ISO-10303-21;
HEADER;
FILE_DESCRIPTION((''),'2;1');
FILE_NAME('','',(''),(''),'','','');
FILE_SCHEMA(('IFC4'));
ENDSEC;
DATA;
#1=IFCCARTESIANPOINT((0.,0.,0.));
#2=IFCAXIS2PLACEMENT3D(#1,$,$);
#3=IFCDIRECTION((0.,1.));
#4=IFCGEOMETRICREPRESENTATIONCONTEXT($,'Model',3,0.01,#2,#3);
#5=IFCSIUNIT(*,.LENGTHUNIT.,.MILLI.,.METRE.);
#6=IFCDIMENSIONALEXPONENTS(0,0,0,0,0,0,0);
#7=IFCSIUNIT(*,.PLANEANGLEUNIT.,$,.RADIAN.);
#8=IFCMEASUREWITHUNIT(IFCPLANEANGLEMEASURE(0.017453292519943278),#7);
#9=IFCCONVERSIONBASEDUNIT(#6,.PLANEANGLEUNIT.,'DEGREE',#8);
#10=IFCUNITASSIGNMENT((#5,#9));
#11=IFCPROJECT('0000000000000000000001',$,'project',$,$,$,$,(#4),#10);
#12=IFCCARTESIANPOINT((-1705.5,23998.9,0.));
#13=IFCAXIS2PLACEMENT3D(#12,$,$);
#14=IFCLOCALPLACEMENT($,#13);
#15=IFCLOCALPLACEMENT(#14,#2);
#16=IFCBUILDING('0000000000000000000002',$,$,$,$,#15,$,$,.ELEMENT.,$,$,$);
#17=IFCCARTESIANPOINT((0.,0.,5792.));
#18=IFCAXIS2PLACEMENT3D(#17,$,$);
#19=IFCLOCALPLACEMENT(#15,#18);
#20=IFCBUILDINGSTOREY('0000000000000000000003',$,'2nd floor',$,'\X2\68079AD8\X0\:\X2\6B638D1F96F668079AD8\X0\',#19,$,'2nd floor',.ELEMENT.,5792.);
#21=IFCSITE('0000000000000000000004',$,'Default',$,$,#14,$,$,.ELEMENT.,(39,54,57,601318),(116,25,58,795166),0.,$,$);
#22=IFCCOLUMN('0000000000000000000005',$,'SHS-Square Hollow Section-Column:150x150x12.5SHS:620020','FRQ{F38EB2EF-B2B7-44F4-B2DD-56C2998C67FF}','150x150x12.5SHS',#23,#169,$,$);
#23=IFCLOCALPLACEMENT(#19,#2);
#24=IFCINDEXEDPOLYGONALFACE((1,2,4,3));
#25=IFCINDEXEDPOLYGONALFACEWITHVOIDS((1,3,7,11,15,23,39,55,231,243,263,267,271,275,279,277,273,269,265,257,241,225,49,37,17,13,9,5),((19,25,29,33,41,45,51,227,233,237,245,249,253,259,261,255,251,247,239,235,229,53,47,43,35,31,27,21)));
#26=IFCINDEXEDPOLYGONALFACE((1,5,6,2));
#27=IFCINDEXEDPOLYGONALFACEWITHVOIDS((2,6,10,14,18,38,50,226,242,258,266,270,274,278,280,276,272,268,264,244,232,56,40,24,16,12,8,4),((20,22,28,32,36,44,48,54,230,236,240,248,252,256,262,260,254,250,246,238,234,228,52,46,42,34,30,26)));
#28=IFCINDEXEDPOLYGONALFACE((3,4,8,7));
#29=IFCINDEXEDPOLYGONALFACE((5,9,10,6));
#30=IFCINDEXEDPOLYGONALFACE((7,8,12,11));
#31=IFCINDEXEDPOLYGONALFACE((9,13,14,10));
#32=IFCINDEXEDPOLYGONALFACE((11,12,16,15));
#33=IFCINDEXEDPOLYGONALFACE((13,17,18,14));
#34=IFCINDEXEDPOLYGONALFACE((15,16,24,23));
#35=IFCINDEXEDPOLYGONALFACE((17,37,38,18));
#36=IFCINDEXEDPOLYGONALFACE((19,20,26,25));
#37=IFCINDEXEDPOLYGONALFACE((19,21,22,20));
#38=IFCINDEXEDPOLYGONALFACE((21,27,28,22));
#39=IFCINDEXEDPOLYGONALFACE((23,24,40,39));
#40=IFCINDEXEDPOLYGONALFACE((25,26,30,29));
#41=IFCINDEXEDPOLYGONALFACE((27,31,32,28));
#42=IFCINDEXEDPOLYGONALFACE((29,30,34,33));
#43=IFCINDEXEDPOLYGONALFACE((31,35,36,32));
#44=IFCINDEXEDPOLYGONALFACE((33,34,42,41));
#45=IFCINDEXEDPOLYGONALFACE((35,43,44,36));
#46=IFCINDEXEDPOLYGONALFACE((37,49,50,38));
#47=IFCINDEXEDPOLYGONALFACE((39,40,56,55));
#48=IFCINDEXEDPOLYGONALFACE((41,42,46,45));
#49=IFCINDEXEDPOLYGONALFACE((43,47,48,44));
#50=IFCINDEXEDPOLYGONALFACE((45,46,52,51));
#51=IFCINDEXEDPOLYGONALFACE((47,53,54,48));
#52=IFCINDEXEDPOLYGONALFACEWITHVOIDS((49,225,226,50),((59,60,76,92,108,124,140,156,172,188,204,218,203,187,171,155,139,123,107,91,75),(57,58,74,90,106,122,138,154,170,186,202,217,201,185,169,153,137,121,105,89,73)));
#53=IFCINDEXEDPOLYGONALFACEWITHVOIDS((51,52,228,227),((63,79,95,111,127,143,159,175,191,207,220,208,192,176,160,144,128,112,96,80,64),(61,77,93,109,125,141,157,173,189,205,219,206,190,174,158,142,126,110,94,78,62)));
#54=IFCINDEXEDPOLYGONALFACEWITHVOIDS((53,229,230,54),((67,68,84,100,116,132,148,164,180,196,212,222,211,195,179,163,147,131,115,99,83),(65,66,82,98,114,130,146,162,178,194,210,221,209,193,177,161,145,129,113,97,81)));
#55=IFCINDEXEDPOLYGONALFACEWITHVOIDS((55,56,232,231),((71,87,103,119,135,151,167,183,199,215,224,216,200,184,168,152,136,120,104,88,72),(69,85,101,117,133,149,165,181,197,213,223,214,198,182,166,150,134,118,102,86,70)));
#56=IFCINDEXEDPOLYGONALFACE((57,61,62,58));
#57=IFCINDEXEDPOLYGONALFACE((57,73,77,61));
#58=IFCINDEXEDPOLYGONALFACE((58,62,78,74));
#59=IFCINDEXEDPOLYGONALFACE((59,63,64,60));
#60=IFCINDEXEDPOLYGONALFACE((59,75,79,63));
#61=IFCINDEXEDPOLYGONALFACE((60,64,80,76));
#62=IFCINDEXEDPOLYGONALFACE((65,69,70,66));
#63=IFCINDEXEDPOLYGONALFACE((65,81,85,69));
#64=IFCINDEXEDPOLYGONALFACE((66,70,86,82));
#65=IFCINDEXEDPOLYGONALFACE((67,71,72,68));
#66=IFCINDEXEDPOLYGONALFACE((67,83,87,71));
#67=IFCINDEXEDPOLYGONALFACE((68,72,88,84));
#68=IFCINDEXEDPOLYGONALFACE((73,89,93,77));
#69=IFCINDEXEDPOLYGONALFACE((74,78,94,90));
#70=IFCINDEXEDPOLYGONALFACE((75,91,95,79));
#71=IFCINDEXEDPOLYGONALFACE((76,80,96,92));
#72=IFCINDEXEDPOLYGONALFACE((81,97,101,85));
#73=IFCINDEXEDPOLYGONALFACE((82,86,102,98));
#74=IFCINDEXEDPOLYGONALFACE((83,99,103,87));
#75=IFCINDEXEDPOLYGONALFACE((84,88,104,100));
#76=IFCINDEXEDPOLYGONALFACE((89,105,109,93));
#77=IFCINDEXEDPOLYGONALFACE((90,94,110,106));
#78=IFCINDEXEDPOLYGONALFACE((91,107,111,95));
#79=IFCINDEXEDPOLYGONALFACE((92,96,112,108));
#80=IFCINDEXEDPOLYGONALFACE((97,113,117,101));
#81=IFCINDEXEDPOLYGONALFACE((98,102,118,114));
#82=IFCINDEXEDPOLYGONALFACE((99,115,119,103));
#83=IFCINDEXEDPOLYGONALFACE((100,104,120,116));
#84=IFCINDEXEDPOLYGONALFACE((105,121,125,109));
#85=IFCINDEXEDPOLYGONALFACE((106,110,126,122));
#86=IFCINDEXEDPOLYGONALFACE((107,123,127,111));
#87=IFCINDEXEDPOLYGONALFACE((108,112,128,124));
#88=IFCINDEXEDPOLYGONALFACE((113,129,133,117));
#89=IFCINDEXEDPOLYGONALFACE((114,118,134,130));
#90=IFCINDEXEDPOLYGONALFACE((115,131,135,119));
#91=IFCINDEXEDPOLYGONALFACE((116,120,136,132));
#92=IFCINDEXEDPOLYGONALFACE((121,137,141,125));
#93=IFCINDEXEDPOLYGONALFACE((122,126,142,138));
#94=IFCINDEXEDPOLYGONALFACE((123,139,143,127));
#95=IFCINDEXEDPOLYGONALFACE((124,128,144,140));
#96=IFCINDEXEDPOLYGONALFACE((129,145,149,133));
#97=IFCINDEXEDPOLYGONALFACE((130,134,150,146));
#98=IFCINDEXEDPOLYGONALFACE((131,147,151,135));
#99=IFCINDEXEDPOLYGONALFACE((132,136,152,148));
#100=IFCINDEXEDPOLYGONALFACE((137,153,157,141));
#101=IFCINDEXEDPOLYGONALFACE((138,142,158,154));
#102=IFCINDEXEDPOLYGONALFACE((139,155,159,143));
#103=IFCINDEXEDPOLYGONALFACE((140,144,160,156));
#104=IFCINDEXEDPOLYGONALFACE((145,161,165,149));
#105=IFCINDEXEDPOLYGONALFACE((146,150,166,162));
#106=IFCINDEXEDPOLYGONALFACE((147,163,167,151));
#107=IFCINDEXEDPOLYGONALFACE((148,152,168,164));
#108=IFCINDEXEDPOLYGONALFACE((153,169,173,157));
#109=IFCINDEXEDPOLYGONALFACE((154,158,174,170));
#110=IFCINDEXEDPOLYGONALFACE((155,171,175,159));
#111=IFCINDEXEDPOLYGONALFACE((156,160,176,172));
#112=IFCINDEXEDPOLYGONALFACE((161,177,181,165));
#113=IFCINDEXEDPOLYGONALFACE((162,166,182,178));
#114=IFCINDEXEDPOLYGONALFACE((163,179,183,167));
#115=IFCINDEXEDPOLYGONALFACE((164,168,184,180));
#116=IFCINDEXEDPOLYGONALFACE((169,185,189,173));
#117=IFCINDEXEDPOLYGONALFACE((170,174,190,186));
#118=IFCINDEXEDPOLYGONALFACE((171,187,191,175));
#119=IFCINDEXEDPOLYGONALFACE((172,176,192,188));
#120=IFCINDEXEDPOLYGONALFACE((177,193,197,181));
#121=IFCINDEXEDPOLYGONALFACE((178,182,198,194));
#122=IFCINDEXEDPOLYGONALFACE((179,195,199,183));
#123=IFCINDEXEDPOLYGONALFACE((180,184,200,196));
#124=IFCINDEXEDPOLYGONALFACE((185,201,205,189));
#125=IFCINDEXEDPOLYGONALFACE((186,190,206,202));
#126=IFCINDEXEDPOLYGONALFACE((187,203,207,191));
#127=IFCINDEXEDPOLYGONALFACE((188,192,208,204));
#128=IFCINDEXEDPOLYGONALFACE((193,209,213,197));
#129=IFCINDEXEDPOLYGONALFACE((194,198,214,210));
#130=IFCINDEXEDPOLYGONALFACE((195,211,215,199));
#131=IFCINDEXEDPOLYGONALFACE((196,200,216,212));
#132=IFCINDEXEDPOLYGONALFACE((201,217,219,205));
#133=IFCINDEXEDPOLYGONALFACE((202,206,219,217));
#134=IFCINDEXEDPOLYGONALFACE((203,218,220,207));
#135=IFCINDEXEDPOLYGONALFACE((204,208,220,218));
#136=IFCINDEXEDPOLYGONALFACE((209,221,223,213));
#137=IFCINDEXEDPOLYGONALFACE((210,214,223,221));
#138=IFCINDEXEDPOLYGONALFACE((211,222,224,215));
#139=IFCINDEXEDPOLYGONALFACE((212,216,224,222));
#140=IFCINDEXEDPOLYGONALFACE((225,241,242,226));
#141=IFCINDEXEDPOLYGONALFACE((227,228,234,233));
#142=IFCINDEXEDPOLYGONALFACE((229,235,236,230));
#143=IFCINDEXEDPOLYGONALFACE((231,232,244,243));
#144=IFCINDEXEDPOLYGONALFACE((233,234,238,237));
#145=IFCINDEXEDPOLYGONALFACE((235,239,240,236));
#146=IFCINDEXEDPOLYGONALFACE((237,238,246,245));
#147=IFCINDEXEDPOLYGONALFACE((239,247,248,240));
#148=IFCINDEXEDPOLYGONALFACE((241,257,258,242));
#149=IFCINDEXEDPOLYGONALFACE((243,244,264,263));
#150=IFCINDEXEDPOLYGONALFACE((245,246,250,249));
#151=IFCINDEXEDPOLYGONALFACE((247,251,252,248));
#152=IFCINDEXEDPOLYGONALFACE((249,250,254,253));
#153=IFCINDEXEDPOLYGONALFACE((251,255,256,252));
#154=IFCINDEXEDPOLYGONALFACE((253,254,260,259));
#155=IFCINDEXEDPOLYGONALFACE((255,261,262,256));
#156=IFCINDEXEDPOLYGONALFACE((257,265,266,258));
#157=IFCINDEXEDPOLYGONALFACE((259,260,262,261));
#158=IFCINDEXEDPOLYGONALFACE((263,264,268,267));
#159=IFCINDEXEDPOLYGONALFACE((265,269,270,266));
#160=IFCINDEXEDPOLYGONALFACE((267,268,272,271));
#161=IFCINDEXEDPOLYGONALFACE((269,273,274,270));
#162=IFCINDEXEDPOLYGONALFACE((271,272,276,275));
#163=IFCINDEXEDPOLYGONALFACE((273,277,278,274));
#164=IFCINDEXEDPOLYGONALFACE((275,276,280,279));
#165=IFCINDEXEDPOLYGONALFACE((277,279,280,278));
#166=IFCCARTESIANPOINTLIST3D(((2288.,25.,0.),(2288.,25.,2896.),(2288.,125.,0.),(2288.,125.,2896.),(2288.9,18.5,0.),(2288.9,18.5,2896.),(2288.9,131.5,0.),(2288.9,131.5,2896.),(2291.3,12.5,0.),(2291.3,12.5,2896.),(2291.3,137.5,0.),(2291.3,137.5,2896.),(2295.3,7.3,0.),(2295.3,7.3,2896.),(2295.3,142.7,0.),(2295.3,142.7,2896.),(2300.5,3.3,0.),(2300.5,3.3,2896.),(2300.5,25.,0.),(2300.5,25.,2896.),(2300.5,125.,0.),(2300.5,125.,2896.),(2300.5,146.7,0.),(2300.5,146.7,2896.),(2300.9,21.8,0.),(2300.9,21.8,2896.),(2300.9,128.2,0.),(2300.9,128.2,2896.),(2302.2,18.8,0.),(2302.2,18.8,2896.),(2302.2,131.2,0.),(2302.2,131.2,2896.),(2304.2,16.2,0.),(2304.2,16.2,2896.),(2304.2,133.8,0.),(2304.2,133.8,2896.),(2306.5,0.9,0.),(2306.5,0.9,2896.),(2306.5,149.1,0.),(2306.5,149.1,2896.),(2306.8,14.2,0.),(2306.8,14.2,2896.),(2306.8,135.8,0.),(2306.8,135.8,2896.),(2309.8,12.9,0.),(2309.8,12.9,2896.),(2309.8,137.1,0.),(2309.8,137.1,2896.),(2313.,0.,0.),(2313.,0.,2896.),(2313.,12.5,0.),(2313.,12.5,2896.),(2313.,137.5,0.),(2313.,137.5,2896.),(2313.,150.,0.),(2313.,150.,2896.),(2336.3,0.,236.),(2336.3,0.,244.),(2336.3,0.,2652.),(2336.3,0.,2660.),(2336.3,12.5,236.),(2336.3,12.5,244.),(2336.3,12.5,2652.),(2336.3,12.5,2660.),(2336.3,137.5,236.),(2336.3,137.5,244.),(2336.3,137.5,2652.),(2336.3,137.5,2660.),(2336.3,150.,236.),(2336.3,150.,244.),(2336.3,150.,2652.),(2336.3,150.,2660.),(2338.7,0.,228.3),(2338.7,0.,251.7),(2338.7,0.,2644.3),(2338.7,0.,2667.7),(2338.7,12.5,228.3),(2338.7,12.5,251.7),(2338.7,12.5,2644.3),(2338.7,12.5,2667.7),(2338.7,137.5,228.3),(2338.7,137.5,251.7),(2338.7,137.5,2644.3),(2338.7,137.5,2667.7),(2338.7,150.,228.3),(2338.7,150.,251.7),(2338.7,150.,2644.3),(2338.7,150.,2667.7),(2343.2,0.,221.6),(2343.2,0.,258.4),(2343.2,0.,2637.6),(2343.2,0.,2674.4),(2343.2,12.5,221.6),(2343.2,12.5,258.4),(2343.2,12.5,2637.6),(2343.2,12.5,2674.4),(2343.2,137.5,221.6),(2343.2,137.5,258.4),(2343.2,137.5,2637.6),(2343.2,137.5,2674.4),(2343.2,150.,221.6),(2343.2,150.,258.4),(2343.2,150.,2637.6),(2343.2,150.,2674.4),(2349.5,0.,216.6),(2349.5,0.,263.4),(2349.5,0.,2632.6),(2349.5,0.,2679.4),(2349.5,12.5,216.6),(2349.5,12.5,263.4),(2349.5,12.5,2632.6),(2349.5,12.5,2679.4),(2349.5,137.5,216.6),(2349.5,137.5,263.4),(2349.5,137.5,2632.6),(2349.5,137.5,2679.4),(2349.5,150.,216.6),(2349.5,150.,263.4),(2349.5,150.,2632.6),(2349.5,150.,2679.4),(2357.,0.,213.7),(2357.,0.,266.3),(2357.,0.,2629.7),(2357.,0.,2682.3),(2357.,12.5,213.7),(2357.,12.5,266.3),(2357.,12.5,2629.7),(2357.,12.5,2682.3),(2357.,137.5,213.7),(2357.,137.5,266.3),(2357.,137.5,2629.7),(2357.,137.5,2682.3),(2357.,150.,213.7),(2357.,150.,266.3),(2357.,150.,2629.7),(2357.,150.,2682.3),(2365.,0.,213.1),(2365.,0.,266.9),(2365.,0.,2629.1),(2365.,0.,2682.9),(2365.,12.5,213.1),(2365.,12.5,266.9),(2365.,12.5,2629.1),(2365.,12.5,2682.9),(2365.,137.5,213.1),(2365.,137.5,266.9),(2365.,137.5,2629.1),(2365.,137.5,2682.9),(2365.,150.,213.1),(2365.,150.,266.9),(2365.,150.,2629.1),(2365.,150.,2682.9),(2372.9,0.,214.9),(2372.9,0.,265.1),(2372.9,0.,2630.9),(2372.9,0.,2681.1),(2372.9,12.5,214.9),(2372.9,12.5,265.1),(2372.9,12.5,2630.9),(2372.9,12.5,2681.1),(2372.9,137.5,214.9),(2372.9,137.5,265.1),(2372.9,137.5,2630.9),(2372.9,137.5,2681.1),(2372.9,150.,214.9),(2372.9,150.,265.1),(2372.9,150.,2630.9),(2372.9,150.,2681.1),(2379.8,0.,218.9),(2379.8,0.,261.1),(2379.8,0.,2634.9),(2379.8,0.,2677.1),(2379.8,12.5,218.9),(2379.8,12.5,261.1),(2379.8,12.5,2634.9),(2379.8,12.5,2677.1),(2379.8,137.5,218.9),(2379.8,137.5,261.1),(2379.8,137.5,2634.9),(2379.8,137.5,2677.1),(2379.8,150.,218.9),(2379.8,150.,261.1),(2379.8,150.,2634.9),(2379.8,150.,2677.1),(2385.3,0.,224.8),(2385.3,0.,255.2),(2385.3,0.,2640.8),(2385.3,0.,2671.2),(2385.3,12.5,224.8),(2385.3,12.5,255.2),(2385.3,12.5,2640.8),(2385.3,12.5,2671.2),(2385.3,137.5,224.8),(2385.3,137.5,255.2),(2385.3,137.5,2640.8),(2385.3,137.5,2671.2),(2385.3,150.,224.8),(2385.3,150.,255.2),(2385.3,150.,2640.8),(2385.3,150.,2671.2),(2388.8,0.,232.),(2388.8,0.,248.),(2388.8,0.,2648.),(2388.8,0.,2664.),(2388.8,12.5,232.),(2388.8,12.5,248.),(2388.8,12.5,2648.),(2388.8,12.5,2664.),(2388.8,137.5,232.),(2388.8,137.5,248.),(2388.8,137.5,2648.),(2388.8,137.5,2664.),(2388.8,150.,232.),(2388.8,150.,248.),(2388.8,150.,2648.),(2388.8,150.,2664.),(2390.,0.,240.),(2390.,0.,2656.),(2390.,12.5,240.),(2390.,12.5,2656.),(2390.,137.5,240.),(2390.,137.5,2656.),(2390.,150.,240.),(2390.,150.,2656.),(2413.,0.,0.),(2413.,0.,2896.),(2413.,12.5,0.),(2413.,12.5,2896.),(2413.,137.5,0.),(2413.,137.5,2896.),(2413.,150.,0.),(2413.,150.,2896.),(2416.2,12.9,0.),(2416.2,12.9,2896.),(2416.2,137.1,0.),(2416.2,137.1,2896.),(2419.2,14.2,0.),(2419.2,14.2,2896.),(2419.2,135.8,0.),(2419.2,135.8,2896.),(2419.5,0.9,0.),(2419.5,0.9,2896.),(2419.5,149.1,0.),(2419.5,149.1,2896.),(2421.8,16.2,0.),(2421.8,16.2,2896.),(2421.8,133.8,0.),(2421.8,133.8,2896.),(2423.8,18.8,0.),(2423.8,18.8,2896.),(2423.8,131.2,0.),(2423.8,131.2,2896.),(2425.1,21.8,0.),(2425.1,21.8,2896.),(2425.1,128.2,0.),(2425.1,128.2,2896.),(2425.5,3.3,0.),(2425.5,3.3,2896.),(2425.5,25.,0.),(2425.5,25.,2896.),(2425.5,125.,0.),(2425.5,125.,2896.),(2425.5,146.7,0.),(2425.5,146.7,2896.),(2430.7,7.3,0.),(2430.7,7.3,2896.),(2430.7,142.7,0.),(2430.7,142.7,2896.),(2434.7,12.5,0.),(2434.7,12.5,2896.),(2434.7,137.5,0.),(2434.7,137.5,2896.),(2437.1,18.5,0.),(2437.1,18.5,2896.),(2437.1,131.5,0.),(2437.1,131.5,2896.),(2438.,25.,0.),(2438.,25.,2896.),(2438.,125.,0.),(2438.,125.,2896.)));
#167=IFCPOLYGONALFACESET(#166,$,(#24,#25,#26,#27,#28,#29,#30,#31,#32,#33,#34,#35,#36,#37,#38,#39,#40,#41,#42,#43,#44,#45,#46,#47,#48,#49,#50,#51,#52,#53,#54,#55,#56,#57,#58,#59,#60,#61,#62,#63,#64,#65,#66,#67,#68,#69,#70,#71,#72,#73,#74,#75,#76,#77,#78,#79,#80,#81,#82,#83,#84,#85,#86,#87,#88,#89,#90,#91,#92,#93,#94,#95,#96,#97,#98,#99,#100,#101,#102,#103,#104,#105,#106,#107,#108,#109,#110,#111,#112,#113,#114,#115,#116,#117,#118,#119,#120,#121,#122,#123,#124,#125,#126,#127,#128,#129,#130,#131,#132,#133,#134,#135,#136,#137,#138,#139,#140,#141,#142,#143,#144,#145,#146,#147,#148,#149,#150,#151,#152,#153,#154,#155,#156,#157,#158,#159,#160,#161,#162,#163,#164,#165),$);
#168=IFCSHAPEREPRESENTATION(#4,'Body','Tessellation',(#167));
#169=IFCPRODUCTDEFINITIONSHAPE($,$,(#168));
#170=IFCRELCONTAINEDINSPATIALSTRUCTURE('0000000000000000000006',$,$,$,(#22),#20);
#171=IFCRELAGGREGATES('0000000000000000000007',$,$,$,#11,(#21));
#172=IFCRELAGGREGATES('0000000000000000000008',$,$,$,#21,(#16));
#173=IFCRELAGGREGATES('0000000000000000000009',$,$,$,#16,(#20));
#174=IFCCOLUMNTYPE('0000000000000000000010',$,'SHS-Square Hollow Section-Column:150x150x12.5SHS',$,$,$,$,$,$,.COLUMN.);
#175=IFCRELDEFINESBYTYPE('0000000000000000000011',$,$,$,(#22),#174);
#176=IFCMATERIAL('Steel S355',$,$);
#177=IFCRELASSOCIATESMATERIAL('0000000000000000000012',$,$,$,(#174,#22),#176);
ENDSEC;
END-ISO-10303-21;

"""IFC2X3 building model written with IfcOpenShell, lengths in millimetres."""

from ifc_helpers import new_model, entity, si_unit, converted_unit, direction, frame, frame_2d, origin, origin_2d, place, context, project, spatial, circle_curve, hollow_rectangle, outline, extrude, material, type_object, element, save


model = new_model("IFC2X3")

# Units and contexts
model_context = context("Model", 3, precision=0.01, world=origin(), true_north=direction((0.0, 1.0)))
ifc_project = project(units=[si_unit("LENGTHUNIT", "METRE", prefix="MILLI"), converted_unit("PLANEANGLEUNIT", "DEGREE", entity("IfcPlaneAngleMeasure", 0.017453292519943278), si_unit("PLANEANGLEUNIT", "RADIAN"), dimensions=[0, 0, 0, 0, 0, 0, 0])], contexts=[model_context])

# Site, building, storey
site_placement = place(None, frame((-1705.5, 23998.9, 0.0)))
site = spatial("IfcSite", under=ifc_project, at=site_placement, Name="Default", CompositionType="ELEMENT", RefLatitude=(39, 54, 57, 601318), RefLongitude=(116, 25, 58, 795166), RefElevation=0.0)
building_placement = place(site_placement, origin())
building = spatial("IfcBuilding", under=site, at=building_placement, CompositionType="ELEMENT")
storey_placement = place(building_placement, frame((0.0, 0.0, 5792.0)))
storey = spatial("IfcBuildingStorey", under=building, at=storey_placement, Name="2nd floor", ObjectType="标高:正负零标高", LongName="2nd floor", CompositionType="ELEMENT", Elevation=5792.0)

# Column, openings
ifc_material_1 = material(Name="Steel S355")
column_type_1 = type_object("IfcColumnType", Name="SHS-Square Hollow Section-Column:150x150x12.5SHS", PredefinedType="COLUMN", material=ifc_material_1)
column_1_placement = place(storey_placement, frame((2363.0, 75.0, 2896.0), z_axis=(0.0, 0.0, 1.0), x_axis=(0.0, -1.0, 0.0)))
column_1 = element("IfcColumn", 1, at=column_1_placement, inside=storey, type_object=column_type_1, material=ifc_material_1, Name="SHS-Square Hollow Section-Column:150x150x12.5SHS:620020", Description="FRQ{F38EB2EF-B2B7-44F4-B2DD-56C2998C67FF}", ObjectType="150x150x12.5SHS", context=model_context, shape_type="SweptSolid", body=[
    extrude(hollow_rectangle(XDim=150.0, YDim=150.0, WallThickness=12.5, InnerFilletRadius=12.5, OuterFilletRadius=25.0, at=origin_2d()), origin(), (0.0, 0.0, -1.0), 2896.0),
])
opening_1_placement = place(column_1_placement, frame((-175.1, 0.0, 0.0), z_axis=(1.0, 0.0, 0.0), x_axis=(0.0, 1.0, 0.0)))
element("IfcOpeningElement", 2, at=opening_1_placement, cuts=column_1, ObjectType="Opening", context=model_context, shape_type="SweptSolid", body=[
    extrude(outline(circle_curve(frame_2d((0.0, -240.0), x_axis=(1.0, 0.0)), 27.0)), origin(), (0.0, 0.0, 1.0), 350.2),
])
opening_2_placement = place(column_1_placement, frame((-175.1, 0.0, -2896.0), z_axis=(1.0, 0.0, 0.0), x_axis=(0.0, 1.0, 0.0)))
element("IfcOpeningElement", 3, at=opening_2_placement, cuts=column_1, ObjectType="Opening", context=model_context, shape_type="SweptSolid", body=[
    extrude(outline(circle_curve(frame_2d((0.0, 240.0), x_axis=(1.0, 0.0)), 27.0)), origin(), (0.0, 0.0, 1.0), 350.2),
])

save(model, "model.ifc")
